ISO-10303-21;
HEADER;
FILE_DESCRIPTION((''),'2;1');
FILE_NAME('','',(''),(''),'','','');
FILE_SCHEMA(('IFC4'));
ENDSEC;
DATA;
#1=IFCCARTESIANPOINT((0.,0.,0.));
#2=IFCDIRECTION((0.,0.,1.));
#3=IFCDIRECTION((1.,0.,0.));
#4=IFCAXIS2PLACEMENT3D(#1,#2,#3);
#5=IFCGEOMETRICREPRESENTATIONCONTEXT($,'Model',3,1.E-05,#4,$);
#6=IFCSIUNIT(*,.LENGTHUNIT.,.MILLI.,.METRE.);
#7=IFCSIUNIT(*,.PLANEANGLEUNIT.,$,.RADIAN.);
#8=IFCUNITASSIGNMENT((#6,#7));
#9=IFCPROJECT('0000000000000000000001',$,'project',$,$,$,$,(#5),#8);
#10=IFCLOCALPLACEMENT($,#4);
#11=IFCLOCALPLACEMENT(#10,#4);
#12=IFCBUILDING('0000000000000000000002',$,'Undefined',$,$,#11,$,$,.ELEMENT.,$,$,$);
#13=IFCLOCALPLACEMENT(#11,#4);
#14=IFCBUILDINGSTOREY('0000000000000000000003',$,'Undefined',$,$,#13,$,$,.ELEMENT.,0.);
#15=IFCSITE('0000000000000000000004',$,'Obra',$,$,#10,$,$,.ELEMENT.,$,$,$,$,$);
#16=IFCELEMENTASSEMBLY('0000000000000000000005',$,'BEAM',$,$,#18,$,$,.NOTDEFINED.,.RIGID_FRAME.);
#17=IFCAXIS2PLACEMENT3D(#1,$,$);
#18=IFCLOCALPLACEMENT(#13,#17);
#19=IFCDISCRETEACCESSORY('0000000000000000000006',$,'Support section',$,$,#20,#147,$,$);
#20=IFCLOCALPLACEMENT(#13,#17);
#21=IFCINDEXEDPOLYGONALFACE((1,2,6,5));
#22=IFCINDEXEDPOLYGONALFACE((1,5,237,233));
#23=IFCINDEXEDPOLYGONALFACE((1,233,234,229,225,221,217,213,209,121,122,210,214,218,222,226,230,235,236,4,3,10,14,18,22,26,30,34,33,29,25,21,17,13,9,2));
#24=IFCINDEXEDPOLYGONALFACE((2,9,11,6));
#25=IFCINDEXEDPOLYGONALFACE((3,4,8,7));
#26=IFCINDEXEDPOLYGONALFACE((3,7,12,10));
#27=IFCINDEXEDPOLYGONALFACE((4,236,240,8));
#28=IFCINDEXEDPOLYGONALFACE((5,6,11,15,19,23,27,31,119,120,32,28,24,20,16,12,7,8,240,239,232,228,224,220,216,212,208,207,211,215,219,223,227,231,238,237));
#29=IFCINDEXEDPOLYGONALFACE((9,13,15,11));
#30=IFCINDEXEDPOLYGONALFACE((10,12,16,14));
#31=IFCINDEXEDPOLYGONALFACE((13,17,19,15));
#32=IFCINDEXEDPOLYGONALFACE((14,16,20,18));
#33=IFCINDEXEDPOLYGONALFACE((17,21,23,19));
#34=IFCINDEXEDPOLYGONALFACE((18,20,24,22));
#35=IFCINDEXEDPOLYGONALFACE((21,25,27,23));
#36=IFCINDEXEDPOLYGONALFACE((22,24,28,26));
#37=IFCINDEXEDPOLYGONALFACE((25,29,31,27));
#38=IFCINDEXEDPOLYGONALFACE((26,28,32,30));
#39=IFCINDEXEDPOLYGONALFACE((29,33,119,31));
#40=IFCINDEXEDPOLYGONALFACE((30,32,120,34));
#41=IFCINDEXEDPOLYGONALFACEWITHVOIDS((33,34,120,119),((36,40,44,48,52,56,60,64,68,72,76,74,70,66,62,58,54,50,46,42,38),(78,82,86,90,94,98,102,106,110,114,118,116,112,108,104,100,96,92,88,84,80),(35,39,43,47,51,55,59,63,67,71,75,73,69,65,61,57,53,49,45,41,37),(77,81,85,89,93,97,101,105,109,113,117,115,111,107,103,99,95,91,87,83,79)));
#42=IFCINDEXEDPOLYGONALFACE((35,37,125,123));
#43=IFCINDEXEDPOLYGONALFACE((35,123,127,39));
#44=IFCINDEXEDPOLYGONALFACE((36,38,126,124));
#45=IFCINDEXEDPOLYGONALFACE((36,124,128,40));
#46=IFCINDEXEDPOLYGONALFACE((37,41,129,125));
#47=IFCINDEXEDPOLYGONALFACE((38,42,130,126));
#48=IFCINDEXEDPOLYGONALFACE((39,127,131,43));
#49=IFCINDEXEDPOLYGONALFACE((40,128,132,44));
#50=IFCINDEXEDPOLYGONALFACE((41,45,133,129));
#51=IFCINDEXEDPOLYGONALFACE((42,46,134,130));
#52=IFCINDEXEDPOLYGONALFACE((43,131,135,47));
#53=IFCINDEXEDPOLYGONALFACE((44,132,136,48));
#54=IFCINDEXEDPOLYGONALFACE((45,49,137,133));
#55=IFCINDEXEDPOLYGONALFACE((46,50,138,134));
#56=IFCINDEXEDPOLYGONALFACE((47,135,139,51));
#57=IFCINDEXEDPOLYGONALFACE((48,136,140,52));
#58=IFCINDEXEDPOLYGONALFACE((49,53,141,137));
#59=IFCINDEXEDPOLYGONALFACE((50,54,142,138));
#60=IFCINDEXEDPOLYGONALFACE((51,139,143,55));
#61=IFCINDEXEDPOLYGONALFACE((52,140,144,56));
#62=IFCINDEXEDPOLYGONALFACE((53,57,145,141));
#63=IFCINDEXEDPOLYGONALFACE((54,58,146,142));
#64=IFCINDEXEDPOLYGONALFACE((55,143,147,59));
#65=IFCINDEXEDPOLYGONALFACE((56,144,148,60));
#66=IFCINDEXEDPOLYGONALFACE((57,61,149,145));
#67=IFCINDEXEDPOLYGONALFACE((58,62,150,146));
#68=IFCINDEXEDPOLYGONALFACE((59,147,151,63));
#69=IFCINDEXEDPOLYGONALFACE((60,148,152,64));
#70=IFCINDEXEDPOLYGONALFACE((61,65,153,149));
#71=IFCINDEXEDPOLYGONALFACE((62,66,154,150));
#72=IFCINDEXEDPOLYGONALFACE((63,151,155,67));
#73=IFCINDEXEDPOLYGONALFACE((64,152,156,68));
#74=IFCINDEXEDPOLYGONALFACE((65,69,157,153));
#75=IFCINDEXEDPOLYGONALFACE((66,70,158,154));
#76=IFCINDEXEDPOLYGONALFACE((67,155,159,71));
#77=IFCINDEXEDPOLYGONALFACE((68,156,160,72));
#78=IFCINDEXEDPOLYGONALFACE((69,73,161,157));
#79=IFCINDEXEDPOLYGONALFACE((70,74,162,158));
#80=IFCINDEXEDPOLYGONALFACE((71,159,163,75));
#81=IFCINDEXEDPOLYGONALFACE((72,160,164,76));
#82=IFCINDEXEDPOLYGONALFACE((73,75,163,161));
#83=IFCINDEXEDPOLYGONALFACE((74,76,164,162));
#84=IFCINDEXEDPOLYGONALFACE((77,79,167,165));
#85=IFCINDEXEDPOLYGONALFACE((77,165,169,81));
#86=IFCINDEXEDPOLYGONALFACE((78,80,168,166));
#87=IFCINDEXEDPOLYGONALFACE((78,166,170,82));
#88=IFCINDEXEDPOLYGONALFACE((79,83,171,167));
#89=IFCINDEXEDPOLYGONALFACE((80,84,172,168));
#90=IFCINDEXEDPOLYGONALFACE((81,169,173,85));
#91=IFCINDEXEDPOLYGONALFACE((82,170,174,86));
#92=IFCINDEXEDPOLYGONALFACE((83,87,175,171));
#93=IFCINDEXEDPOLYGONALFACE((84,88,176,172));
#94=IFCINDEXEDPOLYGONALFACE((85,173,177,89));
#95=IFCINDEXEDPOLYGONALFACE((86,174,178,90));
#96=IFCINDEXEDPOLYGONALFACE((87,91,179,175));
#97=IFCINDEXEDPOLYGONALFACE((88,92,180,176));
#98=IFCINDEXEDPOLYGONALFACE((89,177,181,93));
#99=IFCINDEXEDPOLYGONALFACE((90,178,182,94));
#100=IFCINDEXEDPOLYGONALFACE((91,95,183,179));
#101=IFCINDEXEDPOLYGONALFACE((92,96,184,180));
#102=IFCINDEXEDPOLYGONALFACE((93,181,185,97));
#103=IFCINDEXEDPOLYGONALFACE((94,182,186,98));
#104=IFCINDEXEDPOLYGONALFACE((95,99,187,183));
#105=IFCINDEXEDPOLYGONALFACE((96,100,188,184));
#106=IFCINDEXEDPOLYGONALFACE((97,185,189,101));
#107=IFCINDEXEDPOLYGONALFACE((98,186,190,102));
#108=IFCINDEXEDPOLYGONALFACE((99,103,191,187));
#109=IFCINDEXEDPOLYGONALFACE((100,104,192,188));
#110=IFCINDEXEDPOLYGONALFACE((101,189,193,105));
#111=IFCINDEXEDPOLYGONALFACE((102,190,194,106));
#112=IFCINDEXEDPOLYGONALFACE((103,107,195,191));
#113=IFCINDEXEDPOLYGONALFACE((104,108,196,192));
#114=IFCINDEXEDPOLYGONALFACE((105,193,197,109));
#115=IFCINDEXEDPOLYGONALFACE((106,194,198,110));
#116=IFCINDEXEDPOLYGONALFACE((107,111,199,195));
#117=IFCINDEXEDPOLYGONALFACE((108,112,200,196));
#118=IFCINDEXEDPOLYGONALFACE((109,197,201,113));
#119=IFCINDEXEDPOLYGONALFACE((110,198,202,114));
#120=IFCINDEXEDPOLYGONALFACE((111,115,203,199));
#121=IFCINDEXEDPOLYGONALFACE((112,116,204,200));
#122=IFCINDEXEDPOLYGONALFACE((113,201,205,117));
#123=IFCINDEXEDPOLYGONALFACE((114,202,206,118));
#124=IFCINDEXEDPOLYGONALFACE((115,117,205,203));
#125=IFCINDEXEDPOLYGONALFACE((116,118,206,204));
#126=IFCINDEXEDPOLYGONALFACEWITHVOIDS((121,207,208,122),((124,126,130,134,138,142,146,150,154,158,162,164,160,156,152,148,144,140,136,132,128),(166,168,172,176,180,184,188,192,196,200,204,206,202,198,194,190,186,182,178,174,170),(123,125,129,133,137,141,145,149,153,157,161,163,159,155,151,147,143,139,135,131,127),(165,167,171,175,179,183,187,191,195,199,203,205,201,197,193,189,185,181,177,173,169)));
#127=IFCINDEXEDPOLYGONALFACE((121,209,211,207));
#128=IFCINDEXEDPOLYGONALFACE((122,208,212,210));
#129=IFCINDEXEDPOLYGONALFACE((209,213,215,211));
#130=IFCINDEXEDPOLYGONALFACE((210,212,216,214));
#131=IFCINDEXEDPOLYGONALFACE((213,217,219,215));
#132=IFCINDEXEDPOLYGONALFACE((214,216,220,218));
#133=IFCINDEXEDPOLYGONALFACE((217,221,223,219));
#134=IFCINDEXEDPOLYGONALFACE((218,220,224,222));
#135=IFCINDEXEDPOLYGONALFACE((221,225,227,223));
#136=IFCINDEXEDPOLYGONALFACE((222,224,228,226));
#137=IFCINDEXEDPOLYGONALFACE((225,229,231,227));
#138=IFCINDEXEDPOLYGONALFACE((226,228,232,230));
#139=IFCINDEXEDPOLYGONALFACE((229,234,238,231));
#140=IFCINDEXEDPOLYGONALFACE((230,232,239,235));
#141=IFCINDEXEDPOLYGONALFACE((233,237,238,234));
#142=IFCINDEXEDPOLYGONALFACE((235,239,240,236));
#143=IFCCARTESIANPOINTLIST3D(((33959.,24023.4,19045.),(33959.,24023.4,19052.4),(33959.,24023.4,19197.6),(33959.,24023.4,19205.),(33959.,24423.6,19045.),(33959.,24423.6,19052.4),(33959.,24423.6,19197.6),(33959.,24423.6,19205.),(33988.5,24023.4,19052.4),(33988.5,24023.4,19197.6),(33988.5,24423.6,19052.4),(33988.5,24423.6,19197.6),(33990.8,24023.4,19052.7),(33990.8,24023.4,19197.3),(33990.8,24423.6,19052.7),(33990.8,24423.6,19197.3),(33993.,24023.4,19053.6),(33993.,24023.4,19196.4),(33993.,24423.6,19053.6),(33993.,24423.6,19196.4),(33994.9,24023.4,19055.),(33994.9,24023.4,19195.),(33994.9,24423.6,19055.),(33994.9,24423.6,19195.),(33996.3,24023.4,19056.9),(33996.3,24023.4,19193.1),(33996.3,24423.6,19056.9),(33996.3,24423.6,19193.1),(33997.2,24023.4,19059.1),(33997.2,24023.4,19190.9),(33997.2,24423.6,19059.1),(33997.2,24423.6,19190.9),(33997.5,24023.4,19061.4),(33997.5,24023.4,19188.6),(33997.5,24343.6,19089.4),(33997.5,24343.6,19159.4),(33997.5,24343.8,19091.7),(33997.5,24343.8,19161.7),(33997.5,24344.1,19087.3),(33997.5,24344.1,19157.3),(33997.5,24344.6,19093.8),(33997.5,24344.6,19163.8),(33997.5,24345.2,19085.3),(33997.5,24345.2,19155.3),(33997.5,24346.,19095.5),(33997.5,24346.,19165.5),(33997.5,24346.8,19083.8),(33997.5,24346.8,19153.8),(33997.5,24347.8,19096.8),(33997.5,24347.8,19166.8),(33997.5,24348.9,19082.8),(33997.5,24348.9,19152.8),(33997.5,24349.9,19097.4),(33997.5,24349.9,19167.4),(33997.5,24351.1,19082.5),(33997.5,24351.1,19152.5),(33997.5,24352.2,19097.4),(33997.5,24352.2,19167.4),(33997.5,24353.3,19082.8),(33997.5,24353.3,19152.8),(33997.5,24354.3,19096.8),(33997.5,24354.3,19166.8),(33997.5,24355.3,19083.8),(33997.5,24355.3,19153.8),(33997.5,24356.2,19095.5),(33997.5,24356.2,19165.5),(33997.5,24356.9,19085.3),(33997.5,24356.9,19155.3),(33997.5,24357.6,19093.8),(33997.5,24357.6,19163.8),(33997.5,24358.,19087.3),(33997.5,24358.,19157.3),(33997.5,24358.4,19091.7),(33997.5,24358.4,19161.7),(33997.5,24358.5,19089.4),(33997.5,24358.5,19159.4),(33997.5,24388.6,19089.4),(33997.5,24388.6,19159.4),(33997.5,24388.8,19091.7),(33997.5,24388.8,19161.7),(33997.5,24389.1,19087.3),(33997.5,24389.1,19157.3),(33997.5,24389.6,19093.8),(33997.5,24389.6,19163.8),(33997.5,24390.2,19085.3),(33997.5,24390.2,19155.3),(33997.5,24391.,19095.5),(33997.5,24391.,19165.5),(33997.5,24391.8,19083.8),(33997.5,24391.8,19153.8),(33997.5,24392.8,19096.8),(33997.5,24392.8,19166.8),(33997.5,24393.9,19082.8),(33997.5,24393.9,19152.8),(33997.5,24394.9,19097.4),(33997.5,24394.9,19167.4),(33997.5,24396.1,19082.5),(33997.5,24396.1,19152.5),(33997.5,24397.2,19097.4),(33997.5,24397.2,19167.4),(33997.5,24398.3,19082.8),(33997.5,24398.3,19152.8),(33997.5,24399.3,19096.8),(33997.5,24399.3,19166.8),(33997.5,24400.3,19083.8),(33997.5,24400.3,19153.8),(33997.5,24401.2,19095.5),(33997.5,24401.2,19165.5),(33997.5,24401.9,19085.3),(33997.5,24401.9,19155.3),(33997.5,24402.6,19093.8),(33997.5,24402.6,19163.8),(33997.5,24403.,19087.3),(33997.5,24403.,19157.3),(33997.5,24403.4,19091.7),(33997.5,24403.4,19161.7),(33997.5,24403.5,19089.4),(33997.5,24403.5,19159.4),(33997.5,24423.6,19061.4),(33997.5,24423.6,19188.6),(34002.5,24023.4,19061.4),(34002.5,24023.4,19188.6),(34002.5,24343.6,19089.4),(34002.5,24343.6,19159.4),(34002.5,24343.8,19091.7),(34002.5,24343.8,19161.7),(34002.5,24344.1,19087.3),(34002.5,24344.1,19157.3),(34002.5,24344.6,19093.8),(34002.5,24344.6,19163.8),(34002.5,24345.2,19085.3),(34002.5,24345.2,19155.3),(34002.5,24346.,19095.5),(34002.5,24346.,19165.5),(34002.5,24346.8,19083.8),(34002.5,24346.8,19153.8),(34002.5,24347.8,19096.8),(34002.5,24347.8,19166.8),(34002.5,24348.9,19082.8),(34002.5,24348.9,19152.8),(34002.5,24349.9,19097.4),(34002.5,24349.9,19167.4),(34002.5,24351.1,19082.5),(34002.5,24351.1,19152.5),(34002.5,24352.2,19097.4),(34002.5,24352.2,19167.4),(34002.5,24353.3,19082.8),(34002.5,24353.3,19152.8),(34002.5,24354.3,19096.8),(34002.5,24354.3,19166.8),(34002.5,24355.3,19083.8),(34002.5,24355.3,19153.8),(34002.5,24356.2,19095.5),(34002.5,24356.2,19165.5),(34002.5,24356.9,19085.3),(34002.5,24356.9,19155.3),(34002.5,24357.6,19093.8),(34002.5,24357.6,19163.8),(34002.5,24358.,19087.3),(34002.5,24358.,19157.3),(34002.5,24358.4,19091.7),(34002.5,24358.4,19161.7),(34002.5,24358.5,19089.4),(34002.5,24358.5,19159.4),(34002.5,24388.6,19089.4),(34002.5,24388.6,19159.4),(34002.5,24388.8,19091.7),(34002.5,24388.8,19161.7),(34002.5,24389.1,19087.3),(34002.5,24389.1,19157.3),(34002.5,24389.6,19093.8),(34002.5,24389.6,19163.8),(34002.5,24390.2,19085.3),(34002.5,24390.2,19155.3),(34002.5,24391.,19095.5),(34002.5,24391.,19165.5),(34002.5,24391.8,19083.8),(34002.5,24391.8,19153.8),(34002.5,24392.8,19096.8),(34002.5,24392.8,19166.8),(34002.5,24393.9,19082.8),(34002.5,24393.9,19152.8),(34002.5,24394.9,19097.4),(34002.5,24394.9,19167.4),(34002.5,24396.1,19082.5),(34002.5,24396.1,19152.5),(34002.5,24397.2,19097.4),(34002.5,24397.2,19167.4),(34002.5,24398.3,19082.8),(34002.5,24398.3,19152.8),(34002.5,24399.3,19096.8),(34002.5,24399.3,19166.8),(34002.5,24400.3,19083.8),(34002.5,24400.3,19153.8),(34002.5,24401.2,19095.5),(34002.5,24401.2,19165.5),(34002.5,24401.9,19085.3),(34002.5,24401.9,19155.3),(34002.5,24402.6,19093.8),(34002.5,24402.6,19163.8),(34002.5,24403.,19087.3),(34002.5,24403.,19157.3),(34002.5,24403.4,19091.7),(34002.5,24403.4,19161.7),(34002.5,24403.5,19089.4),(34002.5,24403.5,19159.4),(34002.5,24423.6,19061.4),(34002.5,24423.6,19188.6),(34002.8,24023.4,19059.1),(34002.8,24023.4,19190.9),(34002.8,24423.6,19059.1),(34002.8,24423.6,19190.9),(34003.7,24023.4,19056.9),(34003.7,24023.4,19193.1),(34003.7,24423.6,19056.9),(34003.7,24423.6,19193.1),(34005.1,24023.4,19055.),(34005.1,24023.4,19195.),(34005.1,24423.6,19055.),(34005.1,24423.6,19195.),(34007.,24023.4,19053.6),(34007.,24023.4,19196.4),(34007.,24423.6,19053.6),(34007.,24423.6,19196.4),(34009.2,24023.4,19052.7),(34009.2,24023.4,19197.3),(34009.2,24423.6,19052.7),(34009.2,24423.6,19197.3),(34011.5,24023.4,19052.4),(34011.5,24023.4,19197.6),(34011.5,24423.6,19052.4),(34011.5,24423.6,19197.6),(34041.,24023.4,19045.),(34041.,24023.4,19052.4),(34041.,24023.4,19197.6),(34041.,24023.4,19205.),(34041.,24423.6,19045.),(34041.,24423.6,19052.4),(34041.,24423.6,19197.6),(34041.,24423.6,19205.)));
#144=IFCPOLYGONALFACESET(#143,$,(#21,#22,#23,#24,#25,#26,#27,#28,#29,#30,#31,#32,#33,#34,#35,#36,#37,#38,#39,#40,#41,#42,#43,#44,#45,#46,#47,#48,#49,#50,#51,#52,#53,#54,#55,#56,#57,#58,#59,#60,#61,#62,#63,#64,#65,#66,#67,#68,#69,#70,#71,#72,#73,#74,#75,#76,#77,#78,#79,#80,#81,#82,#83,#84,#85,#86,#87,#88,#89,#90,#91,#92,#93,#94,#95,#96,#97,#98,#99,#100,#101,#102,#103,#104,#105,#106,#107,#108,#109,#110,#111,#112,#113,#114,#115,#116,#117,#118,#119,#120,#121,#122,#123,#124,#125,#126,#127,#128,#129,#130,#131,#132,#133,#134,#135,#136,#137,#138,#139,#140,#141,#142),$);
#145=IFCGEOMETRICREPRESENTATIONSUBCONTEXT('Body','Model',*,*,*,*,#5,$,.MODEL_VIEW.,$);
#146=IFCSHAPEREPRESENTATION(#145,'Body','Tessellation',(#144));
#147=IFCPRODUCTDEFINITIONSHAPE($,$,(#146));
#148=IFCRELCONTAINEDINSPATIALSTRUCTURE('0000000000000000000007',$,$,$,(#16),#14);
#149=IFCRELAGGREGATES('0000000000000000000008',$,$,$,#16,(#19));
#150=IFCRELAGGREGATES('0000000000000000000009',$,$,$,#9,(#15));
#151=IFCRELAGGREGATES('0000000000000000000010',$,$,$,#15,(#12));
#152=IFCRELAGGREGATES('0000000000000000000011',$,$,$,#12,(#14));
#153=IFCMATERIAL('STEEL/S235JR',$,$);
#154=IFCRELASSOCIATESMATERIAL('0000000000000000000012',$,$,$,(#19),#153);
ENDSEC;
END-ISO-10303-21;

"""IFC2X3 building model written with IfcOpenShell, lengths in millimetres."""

from ifc_helpers import new_model, si_unit, frame, origin_with_axes, origin_2d_with_axis, place, context, subcontext, project, spatial, circle, i_section, extrude, clip, halfspace, source, transform, mapped, material, element, aggregate, save


model = new_model("IFC2X3")

# Units and contexts
model_context = context("Model", 3, precision=1e-05, world=origin_with_axes())
body_context = subcontext(model_context, "Body", "Model", "MODEL_VIEW")
ifc_project = project(units=[si_unit("LENGTHUNIT", "METRE", prefix="MILLI"), si_unit("PLANEANGLEUNIT", "RADIAN")], contexts=[model_context])

# Site, building, storey
site_placement = place(None, origin_with_axes())
site = spatial("IfcSite", under=ifc_project, at=site_placement, Name="Obra", CompositionType="ELEMENT")
building_placement = place(site_placement, origin_with_axes())
building = spatial("IfcBuilding", under=site, at=building_placement, Name="Undefined", CompositionType="ELEMENT")
storey_placement = place(building_placement, origin_with_axes())
storey = spatial("IfcBuildingStorey", under=building, at=storey_placement, Name="Undefined", CompositionType="ELEMENT", Elevation=0.0)

# Shared definitions
ifc_material_1 = material(Name="STEEL/S235JR")

# Element assembly
assembly_1_placement = place(storey_placement, origin_with_axes())
assembly_1 = element("IfcElementAssembly", 1, at=assembly_1_placement, inside=storey, Name="BEAM", AssemblyPlace="NOTDEFINED", PredefinedType="RIGID_FRAME")

# Shared definitions
shared_shape_1 = source(origin_with_axes(), body_context, "Body", "SweptSolid", [
    extrude(circle(Radius=7.5, at=origin_2d_with_axis()), frame((0.0, -2.6, 0.0), z_axis=(0.0, 1.0, 0.0), x_axis=(1.0, 0.0, 0.0)), (0.0, 0.0, 1.0), 5.2),
])

# Discrete accessory, opening
discrete_accessory_1_placement = place(assembly_1_placement, frame((34000.0, 24023.4, 19125.0), z_axis=(0.0, 0.0, 1.0), x_axis=(0.0, 1.0, 0.0)))
discrete_accessory_1 = element("IfcDiscreteAccessory", 2, at=discrete_accessory_1_placement, material=ifc_material_1, Name="Support section", context=body_context, shape_type="Clipping", body=[
    clip(extrude(i_section(OverallWidth=82.0, OverallDepth=160.0, WebThickness=5.0, FlangeThickness=7.4, FilletRadius=9.0, at=origin_2d_with_axis()), frame((400.1, 0.0, 0.0), z_axis=(-1.0, 0.0, 0.0), x_axis=(0.0, -1.0, 0.0)), (0.0, 0.0, 1.0), 400.1), halfspace(frame((400.1, 0.0, -180.0), z_axis=(-1.0, 0.0, 0.0), x_axis=(0.0, 1.0, 0.0)), True)),
])
opening_1_placement = place(assembly_1_placement, frame((34000.0, 24373.6, 19160.0), z_axis=(0.0, -1.0, 0.0), x_axis=(0.0, 0.0, -1.0)))
element("IfcOpeningElement", 3, at=opening_1_placement, cuts=discrete_accessory_1, ObjectType="Opening", context=body_context, shape_type="MappedRepresentation", body=[
    mapped(shared_shape_1, transform((0.0, 0.0, -22.5))),
    mapped(shared_shape_1, transform((70.0, 0.0, -22.5))),
    mapped(shared_shape_1, transform((0.0, 0.0, 22.5))),
    mapped(shared_shape_1, transform((70.0, 0.0, 22.5))),
])

aggregate(assembly_1, [discrete_accessory_1])

save(model, "model.ifc")
